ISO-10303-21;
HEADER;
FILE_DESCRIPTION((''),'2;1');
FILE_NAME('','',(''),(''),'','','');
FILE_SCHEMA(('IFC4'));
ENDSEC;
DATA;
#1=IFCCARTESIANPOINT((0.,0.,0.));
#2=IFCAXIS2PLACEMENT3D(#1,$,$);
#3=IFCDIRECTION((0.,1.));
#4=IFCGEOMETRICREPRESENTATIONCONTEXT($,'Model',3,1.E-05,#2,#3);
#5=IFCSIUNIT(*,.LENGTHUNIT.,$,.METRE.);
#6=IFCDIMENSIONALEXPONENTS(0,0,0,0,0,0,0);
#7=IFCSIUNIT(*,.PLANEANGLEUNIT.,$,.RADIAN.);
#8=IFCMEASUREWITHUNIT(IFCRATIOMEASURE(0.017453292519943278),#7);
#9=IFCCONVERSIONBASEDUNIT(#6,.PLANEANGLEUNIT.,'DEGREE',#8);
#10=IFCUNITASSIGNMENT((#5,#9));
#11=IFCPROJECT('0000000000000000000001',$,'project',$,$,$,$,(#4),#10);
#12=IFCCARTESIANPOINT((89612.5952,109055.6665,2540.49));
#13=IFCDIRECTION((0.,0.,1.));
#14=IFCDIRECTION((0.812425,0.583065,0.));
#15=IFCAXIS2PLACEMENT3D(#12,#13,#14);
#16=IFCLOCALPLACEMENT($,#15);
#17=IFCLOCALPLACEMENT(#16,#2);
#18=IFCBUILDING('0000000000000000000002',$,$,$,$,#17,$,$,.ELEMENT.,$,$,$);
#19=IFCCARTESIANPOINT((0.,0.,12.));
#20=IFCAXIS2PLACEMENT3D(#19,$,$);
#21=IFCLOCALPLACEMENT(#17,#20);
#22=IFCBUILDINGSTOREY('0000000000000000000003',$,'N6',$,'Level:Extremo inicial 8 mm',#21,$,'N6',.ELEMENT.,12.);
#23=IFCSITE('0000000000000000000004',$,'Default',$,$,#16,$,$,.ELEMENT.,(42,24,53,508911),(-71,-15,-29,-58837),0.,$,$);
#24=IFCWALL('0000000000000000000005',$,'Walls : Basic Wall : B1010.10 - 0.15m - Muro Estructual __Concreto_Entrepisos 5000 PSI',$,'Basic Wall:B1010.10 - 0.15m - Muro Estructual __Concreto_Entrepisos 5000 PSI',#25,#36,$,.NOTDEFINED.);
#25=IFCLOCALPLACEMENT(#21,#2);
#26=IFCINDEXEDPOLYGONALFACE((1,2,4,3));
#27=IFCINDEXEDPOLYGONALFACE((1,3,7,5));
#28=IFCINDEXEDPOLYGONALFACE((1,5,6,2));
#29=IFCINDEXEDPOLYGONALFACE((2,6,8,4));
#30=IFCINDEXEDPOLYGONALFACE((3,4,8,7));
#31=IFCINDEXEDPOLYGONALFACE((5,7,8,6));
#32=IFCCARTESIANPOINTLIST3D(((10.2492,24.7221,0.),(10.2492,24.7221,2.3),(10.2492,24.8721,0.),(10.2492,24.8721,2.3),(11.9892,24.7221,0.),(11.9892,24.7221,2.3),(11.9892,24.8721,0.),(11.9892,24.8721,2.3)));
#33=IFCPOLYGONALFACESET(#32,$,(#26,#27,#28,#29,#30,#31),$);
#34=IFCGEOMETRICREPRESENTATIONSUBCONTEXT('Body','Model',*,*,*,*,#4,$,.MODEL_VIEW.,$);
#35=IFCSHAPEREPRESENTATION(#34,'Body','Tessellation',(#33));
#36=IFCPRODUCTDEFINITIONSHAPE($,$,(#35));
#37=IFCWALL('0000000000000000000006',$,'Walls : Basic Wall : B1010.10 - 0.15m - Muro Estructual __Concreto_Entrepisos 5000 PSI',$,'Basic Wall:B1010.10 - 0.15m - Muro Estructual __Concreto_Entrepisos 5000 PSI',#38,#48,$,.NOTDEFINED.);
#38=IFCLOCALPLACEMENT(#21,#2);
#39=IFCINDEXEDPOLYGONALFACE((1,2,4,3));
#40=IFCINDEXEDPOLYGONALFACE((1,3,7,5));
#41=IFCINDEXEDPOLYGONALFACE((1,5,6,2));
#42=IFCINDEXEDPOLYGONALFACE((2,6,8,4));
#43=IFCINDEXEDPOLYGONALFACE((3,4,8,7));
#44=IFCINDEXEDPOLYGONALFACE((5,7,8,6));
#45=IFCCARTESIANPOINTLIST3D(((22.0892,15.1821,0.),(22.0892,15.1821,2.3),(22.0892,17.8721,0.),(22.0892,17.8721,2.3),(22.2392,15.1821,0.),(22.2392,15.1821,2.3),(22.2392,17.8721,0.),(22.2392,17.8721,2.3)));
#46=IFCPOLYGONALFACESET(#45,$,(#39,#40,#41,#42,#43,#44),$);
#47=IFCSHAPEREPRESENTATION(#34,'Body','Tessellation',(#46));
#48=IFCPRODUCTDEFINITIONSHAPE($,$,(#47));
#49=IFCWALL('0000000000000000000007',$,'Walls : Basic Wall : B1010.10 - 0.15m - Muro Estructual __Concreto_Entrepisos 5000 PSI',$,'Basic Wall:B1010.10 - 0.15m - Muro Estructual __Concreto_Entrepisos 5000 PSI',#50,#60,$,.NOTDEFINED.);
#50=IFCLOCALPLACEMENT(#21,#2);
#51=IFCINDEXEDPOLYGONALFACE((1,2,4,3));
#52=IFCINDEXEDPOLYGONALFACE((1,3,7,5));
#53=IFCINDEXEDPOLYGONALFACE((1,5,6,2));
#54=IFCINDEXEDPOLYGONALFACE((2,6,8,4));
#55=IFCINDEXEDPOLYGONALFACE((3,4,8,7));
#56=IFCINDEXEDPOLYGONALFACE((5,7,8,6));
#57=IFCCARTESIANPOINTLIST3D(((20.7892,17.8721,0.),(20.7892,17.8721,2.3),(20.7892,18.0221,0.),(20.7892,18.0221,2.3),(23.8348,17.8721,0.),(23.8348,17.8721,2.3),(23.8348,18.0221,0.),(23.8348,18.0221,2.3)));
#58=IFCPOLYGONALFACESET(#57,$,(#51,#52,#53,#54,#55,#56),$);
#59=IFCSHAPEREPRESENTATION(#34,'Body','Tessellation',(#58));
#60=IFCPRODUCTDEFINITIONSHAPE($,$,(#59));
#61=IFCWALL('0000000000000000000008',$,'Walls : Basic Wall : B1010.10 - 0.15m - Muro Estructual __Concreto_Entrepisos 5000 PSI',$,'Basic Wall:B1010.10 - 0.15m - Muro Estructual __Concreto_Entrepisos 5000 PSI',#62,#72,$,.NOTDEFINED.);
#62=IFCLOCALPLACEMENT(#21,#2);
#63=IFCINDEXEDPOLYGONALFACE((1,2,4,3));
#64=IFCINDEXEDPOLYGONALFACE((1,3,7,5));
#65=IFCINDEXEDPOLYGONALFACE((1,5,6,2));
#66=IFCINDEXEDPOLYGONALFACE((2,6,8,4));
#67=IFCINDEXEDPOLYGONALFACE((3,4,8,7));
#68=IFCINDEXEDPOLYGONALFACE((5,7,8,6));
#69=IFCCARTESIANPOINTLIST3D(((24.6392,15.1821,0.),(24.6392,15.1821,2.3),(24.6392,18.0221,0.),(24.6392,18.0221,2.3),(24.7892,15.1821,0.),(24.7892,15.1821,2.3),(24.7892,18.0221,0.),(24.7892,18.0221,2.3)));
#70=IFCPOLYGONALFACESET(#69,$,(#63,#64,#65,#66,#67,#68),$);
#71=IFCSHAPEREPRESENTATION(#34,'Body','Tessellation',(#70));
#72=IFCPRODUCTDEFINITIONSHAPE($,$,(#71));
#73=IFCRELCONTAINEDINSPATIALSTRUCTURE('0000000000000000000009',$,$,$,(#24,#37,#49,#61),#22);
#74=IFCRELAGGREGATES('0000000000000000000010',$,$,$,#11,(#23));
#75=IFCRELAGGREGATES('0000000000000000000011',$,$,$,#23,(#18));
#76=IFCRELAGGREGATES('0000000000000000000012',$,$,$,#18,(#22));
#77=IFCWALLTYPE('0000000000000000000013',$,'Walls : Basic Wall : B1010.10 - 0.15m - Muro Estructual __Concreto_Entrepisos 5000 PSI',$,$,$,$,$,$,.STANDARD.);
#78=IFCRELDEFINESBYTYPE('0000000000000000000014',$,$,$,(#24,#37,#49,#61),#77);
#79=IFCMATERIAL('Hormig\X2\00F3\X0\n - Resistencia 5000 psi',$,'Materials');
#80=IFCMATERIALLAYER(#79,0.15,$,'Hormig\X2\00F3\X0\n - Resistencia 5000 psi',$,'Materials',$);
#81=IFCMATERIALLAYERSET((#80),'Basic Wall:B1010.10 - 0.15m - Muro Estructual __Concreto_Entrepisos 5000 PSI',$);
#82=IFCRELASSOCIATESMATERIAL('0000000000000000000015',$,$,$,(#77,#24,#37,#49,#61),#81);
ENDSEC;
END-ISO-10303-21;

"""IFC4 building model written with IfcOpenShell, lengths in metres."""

from ifc_helpers import new_model, entity, si_unit, converted_unit, direction, frame, frame_2d, origin, place, context, subcontext, project, spatial, rectangle, extrude, material, layer, layer_set, layer_usage, type_object, element, save


model = new_model("IFC4")

# Units and contexts
model_context = context("Model", 3, precision=1e-05, world=origin(), true_north=direction((0.0, 1.0)))
body_context = subcontext(model_context, "Body", "Model", "MODEL_VIEW")
ifc_project = project(units=[si_unit("LENGTHUNIT", "METRE"), converted_unit("PLANEANGLEUNIT", "DEGREE", entity("IfcRatioMeasure", 0.017453292519943278), si_unit("PLANEANGLEUNIT", "RADIAN"), dimensions=[0, 0, 0, 0, 0, 0, 0])], contexts=[model_context])

# Site, building, storey
site_placement = place(None, frame((89612.5952, 109055.6665, 2540.49), z_axis=(0.0, 0.0, 1.0), x_axis=(0.812425, 0.583065, 0.0)))
site = spatial("IfcSite", under=ifc_project, at=site_placement, Name="Default", CompositionType="ELEMENT", RefLatitude=(42, 24, 53, 508911), RefLongitude=(-71, -15, -29, -58837), RefElevation=0.0)
building_placement = place(site_placement, origin())
building = spatial("IfcBuilding", under=site, at=building_placement, CompositionType="ELEMENT")
storey_placement = place(building_placement, frame((0.0, 0.0, 12.0)))
storey = spatial("IfcBuildingStorey", under=building, at=storey_placement, Name="N6", ObjectType="Level:Extremo inicial 8 mm", LongName="N6", CompositionType="ELEMENT", Elevation=12.0)

# Walls
ifc_material = material(Name="Hormigón - Resistencia 5000 psi", Category="Materials")
ifc_layer_1 = layer(ifc_material, 0.15, Name="Hormigón - Resistencia 5000 psi", Category="Materials")
ifc_layer_set_1 = layer_set([ifc_layer_1], Name="Basic Wall:B1010.10 - 0.15m - Muro Estructual __Concreto_Entrepisos 5000 PSI")
wall_type_1 = type_object("IfcWallType", Name="Walls : Basic Wall : B1010.10 - 0.15m - Muro Estructual __Concreto_Entrepisos 5000 PSI", PredefinedType="STANDARD", material=ifc_layer_set_1)
ifc_layer_usage_1 = layer_usage(ifc_layer_set_1, "AXIS2", "POSITIVE", -0.075)
wall_1_placement = place(storey_placement, frame((11.9892, 24.7971, 0.0), z_axis=(0.0, 0.0, 1.0), x_axis=(-1.0, 0.0, 0.0)))
element("IfcWall", 1, at=wall_1_placement, inside=storey, type_object=wall_type_1, material=ifc_layer_usage_1, Name="Walls : Basic Wall : B1010.10 - 0.15m - Muro Estructual __Concreto_Entrepisos 5000 PSI", ObjectType="Basic Wall:B1010.10 - 0.15m - Muro Estructual __Concreto_Entrepisos 5000 PSI", PredefinedType="NOTDEFINED", context=body_context, shape_type="SweptSolid", body=[
    extrude(rectangle(XDim=1.74, YDim=0.15, at=frame_2d((0.87, 0.0), x_axis=(-1.0, 0.0))), origin(), (0.0, 0.0, 1.0), 2.3),
])
ifc_layer_usage_2 = layer_usage(ifc_layer_set_1, "AXIS2", "POSITIVE", -0.075)
wall_2_placement = place(storey_placement, frame((22.1642, 15.1821, 0.0), z_axis=(0.0, 0.0, 1.0), x_axis=(0.0, 1.0, 0.0)))
element("IfcWall", 2, at=wall_2_placement, inside=storey, type_object=wall_type_1, material=ifc_layer_usage_2, Name="Walls : Basic Wall : B1010.10 - 0.15m - Muro Estructual __Concreto_Entrepisos 5000 PSI", ObjectType="Basic Wall:B1010.10 - 0.15m - Muro Estructual __Concreto_Entrepisos 5000 PSI", PredefinedType="NOTDEFINED", context=body_context, shape_type="SweptSolid", body=[
    extrude(rectangle(XDim=2.69, YDim=0.15, at=frame_2d((1.345, 0.0), x_axis=(-1.0, 0.0))), origin(), (0.0, 0.0, 1.0), 2.3),
])
ifc_layer_usage_3 = layer_usage(ifc_layer_set_1, "AXIS2", "POSITIVE", -0.075)
wall_3_placement = place(storey_placement, frame((20.7892, 17.9471, 0.0)))
element("IfcWall", 3, at=wall_3_placement, inside=storey, type_object=wall_type_1, material=ifc_layer_usage_3, Name="Walls : Basic Wall : B1010.10 - 0.15m - Muro Estructual __Concreto_Entrepisos 5000 PSI", ObjectType="Basic Wall:B1010.10 - 0.15m - Muro Estructual __Concreto_Entrepisos 5000 PSI", PredefinedType="NOTDEFINED", context=body_context, shape_type="SweptSolid", body=[
    extrude(rectangle(XDim=3.0455, YDim=0.15, at=frame_2d((1.5228, 0.0), x_axis=(-1.0, 0.0))), origin(), (0.0, 0.0, 1.0), 2.3),
])
ifc_layer_usage_4 = layer_usage(ifc_layer_set_1, "AXIS2", "POSITIVE", -0.075)
wall_4_placement = place(storey_placement, frame((24.7142, 15.1821, 0.0), z_axis=(0.0, 0.0, 1.0), x_axis=(0.0, 1.0, 0.0)))
element("IfcWall", 4, at=wall_4_placement, inside=storey, type_object=wall_type_1, material=ifc_layer_usage_4, Name="Walls : Basic Wall : B1010.10 - 0.15m - Muro Estructual __Concreto_Entrepisos 5000 PSI", ObjectType="Basic Wall:B1010.10 - 0.15m - Muro Estructual __Concreto_Entrepisos 5000 PSI", PredefinedType="NOTDEFINED", context=body_context, shape_type="SweptSolid", body=[
    extrude(rectangle(XDim=2.84, YDim=0.15, at=frame_2d((1.42, 0.0), x_axis=(-1.0, 0.0))), origin(), (0.0, 0.0, 1.0), 2.3),
])

save(model, "model.ifc")
